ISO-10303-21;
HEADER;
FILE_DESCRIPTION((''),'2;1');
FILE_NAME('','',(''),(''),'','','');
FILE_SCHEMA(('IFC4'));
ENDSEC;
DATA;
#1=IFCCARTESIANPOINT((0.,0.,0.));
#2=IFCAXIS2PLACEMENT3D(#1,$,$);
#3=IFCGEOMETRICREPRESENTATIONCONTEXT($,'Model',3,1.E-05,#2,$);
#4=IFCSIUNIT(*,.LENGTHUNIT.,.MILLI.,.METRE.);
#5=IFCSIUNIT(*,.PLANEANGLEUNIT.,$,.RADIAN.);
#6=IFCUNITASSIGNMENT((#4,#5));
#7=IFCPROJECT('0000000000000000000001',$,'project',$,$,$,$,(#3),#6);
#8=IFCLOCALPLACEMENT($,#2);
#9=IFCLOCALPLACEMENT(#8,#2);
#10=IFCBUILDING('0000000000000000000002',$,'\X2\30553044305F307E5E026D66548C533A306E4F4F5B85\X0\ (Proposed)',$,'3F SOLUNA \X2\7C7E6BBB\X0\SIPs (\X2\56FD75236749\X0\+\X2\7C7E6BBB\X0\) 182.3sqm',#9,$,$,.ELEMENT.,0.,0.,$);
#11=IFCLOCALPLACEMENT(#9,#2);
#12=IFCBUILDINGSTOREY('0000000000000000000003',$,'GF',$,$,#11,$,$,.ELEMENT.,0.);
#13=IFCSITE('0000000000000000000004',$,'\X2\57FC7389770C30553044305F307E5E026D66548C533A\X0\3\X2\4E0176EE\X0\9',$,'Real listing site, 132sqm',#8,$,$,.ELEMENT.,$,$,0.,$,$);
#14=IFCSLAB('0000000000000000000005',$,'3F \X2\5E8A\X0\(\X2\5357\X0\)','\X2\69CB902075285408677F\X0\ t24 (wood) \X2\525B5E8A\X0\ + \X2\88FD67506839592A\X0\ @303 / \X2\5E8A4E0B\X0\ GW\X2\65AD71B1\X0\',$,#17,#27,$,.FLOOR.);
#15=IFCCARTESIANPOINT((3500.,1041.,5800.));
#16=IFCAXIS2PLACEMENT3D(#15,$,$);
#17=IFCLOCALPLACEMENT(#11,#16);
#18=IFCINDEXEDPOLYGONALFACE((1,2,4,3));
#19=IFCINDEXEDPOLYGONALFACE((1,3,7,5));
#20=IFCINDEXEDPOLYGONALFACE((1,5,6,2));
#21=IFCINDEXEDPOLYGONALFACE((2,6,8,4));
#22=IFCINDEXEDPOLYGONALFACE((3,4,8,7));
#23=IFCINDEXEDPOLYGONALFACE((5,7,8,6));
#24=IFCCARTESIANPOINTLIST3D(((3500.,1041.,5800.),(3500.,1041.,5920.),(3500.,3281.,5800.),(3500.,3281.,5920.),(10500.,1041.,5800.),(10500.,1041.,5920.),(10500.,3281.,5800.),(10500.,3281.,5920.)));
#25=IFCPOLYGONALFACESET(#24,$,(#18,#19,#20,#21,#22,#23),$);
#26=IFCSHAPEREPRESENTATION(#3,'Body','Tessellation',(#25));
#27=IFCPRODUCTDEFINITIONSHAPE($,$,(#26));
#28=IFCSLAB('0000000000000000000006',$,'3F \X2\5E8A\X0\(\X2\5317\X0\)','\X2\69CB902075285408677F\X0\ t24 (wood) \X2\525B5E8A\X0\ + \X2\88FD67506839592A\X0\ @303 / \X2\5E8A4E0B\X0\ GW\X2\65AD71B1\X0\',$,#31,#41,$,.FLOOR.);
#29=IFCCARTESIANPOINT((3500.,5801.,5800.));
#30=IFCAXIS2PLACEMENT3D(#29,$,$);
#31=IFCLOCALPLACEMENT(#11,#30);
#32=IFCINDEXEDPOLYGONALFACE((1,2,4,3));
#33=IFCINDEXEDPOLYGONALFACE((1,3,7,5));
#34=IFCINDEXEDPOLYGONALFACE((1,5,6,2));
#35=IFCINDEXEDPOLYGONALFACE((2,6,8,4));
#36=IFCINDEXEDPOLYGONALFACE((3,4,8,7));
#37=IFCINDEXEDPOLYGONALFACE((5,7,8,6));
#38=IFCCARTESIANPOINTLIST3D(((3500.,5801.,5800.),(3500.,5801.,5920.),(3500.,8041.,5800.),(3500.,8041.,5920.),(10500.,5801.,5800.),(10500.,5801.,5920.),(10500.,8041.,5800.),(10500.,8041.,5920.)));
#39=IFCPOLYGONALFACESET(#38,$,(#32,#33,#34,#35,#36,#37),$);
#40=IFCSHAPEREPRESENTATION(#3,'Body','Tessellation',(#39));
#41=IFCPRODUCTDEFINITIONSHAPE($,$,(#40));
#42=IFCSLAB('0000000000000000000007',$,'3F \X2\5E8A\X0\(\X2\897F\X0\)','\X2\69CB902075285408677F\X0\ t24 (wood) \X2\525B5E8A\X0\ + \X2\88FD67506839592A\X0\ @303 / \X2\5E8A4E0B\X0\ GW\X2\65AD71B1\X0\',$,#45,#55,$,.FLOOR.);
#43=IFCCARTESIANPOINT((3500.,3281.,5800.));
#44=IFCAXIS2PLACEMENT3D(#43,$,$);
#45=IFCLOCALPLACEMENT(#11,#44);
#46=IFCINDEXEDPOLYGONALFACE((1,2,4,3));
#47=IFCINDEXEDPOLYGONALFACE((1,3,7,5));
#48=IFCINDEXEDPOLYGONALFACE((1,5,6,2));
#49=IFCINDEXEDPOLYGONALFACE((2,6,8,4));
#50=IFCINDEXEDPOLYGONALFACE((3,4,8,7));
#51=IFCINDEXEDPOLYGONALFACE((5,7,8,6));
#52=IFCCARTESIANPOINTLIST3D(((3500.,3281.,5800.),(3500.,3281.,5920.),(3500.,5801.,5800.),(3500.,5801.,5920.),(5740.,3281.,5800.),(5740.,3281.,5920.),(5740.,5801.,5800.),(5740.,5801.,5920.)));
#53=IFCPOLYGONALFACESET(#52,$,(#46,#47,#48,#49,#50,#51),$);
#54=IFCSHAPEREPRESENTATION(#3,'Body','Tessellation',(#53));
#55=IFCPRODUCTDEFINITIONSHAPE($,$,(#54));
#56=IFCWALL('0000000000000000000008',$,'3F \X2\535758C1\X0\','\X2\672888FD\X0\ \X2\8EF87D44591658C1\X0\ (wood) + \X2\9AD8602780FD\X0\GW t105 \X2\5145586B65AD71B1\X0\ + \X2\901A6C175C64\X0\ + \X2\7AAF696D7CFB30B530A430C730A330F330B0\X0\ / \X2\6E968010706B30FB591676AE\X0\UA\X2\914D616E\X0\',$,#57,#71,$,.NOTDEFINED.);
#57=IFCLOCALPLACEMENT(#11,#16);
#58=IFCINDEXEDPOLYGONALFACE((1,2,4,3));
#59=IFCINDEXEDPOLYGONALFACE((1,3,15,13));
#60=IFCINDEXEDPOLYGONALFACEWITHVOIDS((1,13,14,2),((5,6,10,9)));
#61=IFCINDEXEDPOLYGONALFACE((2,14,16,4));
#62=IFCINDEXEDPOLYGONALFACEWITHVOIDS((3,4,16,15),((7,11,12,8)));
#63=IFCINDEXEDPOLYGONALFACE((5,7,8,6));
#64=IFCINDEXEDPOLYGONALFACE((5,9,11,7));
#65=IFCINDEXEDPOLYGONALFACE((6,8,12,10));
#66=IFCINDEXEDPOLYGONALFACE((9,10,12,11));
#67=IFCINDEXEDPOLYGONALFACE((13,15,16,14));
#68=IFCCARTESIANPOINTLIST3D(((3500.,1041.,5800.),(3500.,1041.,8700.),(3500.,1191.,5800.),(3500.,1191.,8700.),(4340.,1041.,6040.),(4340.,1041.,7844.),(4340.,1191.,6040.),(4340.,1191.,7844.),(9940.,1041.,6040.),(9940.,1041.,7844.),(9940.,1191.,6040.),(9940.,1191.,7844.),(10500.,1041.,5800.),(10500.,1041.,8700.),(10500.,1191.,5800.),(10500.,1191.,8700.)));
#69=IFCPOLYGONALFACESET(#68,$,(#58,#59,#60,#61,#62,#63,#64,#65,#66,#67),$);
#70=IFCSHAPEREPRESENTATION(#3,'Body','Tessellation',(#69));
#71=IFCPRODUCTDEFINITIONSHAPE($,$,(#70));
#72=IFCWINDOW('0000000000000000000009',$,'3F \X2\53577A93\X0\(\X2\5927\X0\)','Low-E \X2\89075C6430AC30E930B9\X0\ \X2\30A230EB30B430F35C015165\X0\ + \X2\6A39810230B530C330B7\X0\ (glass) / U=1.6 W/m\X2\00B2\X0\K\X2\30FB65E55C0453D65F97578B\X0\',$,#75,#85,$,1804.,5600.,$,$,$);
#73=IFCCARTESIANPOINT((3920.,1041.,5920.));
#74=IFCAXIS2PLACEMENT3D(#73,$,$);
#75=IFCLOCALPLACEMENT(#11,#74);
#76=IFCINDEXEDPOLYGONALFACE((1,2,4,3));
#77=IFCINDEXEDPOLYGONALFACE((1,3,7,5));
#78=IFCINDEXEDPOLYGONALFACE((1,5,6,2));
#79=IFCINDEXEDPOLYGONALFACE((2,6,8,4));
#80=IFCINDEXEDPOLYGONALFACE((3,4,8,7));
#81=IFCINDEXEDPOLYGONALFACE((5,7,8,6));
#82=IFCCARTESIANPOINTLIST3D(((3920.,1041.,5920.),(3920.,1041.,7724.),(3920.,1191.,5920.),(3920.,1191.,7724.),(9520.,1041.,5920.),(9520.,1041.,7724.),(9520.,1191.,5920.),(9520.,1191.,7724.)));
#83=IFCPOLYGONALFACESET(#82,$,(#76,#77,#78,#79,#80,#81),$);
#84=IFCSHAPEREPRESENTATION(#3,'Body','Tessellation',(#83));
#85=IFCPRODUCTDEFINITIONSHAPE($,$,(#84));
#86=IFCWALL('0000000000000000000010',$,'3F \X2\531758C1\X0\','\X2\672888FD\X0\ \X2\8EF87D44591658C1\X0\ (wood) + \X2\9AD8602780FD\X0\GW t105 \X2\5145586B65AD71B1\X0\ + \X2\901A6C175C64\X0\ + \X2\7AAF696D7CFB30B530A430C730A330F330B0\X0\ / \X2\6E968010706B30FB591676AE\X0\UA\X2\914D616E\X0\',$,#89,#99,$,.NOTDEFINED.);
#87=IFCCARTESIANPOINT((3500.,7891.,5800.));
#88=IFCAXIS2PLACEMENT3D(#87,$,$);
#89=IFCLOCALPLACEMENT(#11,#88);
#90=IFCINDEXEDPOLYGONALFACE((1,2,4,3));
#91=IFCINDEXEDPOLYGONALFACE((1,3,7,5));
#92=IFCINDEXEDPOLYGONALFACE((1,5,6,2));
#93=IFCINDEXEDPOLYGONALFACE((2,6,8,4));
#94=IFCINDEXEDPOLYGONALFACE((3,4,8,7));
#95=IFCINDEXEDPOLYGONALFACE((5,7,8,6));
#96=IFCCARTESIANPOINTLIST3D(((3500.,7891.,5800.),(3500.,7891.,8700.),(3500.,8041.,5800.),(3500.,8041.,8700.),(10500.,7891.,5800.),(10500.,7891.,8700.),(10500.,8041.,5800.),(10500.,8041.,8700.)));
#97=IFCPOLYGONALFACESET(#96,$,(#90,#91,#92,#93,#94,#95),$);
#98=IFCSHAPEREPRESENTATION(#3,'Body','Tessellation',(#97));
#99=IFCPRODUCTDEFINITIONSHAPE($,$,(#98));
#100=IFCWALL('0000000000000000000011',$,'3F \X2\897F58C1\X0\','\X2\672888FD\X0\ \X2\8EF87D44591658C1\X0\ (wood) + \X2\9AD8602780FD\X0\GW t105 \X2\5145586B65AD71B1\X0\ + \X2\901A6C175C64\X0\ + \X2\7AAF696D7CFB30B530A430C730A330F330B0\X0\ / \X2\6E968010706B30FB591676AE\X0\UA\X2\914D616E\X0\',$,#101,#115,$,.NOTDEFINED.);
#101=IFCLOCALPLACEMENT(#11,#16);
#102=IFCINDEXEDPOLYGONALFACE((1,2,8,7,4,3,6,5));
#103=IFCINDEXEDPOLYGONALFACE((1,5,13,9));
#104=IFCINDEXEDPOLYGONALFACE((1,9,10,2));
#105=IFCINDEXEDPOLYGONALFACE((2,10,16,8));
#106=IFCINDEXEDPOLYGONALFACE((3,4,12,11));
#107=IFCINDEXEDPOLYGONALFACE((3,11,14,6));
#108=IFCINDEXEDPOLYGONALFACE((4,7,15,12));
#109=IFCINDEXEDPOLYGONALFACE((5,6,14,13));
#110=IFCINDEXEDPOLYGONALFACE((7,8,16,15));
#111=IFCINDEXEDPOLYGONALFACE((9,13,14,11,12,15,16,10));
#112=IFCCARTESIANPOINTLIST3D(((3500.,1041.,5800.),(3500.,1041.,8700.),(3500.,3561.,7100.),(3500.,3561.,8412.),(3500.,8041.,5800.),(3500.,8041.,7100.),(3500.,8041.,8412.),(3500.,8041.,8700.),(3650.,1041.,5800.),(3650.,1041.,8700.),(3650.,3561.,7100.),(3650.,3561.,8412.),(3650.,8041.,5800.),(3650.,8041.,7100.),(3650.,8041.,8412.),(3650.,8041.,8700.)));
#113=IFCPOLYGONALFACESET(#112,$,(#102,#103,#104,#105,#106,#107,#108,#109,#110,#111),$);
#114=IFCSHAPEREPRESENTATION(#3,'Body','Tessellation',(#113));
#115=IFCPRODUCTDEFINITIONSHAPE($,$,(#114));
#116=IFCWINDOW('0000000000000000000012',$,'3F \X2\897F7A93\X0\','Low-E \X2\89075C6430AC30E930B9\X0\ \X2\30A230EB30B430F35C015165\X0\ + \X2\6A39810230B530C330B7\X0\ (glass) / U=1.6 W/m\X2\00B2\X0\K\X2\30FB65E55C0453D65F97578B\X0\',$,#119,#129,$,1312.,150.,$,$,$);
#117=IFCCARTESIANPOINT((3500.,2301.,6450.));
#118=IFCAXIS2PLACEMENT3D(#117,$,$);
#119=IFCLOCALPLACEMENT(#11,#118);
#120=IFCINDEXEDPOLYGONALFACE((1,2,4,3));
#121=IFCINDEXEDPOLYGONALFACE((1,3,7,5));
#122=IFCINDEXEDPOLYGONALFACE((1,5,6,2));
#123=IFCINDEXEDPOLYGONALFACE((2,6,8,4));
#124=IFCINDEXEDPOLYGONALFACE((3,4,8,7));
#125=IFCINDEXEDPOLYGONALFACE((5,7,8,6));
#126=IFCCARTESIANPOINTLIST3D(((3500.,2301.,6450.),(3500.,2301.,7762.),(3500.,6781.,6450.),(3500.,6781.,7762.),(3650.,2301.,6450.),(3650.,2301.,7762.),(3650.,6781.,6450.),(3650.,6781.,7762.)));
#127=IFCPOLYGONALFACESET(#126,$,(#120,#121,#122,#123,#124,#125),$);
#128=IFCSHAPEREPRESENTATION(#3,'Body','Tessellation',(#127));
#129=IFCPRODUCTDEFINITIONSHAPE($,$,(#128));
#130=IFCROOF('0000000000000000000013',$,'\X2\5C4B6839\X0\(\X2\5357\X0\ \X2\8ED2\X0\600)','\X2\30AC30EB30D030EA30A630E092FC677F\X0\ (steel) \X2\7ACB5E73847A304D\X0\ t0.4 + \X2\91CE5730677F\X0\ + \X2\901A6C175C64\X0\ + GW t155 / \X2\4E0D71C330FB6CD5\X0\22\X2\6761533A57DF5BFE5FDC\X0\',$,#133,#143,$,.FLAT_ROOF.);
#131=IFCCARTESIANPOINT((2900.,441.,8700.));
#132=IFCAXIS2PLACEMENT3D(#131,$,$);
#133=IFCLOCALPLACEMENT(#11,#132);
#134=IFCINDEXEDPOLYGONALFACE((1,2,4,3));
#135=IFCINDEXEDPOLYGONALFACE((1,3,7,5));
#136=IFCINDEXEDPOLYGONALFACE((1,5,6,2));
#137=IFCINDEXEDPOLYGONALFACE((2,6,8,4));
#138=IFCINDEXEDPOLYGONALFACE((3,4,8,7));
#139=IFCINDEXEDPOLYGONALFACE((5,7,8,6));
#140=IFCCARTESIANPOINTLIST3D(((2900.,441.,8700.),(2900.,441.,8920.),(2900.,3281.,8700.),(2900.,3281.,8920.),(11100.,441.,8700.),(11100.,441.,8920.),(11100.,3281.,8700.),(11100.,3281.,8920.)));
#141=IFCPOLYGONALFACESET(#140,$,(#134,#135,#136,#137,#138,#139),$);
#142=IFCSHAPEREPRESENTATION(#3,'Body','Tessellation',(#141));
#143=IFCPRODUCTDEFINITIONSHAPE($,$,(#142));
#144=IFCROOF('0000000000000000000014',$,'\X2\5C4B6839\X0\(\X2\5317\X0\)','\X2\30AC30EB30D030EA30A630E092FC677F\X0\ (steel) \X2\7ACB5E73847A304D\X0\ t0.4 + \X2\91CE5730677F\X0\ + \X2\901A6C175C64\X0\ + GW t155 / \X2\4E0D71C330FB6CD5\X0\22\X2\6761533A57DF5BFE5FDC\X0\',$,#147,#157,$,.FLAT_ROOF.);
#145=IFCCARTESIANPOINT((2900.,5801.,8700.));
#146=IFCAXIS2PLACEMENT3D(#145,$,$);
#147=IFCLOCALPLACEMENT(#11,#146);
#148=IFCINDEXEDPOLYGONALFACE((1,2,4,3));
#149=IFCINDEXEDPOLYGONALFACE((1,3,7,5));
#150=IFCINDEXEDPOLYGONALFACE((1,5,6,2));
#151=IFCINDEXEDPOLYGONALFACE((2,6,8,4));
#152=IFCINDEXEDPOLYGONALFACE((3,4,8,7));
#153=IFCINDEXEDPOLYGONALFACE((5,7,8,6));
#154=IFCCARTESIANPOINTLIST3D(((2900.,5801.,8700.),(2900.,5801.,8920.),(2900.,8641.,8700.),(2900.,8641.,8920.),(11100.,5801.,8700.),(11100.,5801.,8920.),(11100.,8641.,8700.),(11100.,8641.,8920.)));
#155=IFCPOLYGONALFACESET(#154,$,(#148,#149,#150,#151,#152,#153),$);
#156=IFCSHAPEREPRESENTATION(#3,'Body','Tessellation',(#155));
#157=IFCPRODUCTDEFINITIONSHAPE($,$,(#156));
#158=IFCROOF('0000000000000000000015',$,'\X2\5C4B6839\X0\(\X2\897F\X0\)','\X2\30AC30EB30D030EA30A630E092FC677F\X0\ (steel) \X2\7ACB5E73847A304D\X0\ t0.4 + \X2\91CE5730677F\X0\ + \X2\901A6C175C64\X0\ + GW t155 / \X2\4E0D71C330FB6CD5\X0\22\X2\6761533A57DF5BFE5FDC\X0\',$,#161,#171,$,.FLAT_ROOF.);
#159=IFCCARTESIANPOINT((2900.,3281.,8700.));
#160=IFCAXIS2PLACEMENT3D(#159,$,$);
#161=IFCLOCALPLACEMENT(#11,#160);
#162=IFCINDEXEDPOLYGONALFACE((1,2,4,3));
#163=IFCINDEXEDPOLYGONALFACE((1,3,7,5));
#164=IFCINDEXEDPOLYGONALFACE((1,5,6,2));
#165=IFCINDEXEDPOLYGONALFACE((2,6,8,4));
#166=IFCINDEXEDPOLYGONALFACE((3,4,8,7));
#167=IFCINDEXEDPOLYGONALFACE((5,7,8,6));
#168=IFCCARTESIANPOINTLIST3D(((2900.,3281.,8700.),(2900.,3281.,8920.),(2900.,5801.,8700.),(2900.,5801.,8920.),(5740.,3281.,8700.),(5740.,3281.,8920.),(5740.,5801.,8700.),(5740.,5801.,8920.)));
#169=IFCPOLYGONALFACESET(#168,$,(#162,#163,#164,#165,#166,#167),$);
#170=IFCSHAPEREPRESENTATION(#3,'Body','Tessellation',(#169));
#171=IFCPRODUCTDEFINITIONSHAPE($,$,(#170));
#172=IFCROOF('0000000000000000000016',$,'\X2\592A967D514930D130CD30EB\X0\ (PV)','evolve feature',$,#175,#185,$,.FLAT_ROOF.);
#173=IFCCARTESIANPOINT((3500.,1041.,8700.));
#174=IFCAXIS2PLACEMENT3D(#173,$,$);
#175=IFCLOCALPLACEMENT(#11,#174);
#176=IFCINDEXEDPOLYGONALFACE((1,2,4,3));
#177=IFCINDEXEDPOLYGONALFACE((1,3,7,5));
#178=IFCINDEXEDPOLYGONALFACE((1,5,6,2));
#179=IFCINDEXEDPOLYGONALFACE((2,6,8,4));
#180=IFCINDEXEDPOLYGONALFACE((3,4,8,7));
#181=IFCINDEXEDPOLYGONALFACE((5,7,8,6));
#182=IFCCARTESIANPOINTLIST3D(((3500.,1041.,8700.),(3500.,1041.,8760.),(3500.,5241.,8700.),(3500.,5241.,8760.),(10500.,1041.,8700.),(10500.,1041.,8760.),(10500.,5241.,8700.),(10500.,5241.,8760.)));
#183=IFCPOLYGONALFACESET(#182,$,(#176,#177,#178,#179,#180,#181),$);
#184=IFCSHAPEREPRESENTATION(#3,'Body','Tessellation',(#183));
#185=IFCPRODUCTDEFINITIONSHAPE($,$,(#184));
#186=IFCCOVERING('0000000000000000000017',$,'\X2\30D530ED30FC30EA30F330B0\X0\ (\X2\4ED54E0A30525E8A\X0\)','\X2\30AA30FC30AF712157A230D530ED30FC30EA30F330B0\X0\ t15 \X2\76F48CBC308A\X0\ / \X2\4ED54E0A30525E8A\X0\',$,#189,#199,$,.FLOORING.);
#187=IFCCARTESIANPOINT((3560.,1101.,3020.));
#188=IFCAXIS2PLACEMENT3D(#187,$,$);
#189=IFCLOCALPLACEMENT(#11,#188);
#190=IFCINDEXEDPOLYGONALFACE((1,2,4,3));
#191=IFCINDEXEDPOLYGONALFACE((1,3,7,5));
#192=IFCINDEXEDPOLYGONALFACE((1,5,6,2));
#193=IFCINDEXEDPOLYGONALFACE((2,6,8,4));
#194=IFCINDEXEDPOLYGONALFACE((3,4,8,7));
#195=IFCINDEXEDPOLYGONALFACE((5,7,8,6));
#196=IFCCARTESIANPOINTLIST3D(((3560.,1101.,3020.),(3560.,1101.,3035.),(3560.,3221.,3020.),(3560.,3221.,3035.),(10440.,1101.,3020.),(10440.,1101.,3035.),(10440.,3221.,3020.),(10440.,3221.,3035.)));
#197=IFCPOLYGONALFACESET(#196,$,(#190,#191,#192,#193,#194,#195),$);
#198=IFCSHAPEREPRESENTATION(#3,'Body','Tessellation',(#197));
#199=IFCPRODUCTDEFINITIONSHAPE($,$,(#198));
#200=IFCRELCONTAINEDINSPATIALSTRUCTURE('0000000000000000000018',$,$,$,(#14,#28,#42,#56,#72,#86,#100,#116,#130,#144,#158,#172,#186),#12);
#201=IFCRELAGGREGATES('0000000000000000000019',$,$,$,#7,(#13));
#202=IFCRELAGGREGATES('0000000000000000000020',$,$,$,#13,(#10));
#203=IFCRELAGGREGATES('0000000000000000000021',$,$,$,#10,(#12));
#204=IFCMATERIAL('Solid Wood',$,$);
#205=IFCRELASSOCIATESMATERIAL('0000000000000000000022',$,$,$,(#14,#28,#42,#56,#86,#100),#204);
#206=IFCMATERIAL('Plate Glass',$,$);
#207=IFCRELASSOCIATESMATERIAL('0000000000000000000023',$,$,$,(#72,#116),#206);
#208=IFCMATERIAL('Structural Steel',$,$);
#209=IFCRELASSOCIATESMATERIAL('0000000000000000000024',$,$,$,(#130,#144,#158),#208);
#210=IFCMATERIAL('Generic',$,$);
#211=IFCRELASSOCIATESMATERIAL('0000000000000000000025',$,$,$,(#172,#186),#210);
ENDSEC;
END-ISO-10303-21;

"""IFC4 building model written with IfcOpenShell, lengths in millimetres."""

from ifc_helpers import new_model, si_unit, frame, frame_2d, origin, place, context, project, spatial, rectangle, extrude, material, element, fill, save


model = new_model("IFC4")

# Units and contexts
model_context = context("Model", 3, precision=1e-05, world=origin())
ifc_project = project(units=[si_unit("LENGTHUNIT", "METRE", prefix="MILLI"), si_unit("PLANEANGLEUNIT", "RADIAN")], contexts=[model_context])

# Site, building, storey
site_placement = place(None, origin())
site = spatial("IfcSite", under=ifc_project, at=site_placement, Name="埼玉県さいたま市浦和区3丁目9", ObjectType="Real listing site, 132sqm", CompositionType="ELEMENT", RefElevation=0.0)
building_placement = place(site_placement, origin())
building = spatial("IfcBuilding", under=site, at=building_placement, Name="さいたま市浦和区の住宅 (Proposed)", ObjectType="3F SOLUNA 籾殻SIPs (国産杉+籾殻) 182.3sqm", CompositionType="ELEMENT", ElevationOfRefHeight=0.0, ElevationOfTerrain=0.0)
storey_placement = place(building_placement, origin())
storey = spatial("IfcBuildingStorey", under=building, at=storey_placement, Name="GF", CompositionType="ELEMENT", Elevation=0.0)

# Slabs
ifc_material_1 = material(Name="Solid Wood")
slab_1_placement = place(storey_placement, frame((3500.0, 1041.0, 5800.0)))
element("IfcSlab", 1, at=slab_1_placement, inside=storey, material=ifc_material_1, Name="3F 床(南)", Description="構造用合板 t24 (wood) 剛床 + 製材根太 @303 / 床下 GW断熱", PredefinedType="FLOOR", context=model_context, shape_type="SweptSolid", body=[
    extrude(rectangle(XDim=7000.0, YDim=2240.0, at=frame_2d((3500.0, 1120.0))), frame((3500.0, 1041.0, 5800.0)), (0.0, 0.0, 1.0), 120.0),
])
slab_2_placement = place(storey_placement, frame((3500.0, 5801.0, 5800.0)))
element("IfcSlab", 2, at=slab_2_placement, inside=storey, material=ifc_material_1, Name="3F 床(北)", Description="構造用合板 t24 (wood) 剛床 + 製材根太 @303 / 床下 GW断熱", PredefinedType="FLOOR", context=model_context, shape_type="SweptSolid", body=[
    extrude(rectangle(XDim=7000.0, YDim=2240.0, at=frame_2d((3500.0, 1120.0))), frame((3500.0, 5801.0, 5800.0)), (0.0, 0.0, 1.0), 120.0),
])
slab_3_placement = place(storey_placement, frame((3500.0, 3281.0, 5800.0)))
element("IfcSlab", 3, at=slab_3_placement, inside=storey, material=ifc_material_1, Name="3F 床(西)", Description="構造用合板 t24 (wood) 剛床 + 製材根太 @303 / 床下 GW断熱", PredefinedType="FLOOR", context=model_context, shape_type="SweptSolid", body=[
    extrude(rectangle(XDim=2240.0, YDim=2520.0, at=frame_2d((1120.0, 1260.0))), frame((3500.0, 3281.0, 5800.0)), (0.0, 0.0, 1.0), 120.0),
])

# Wall, opening, window
wall_1_placement = place(storey_placement, frame((3500.0, 1041.0, 5800.0)))
wall_1 = element("IfcWall", 4, at=wall_1_placement, inside=storey, material=ifc_material_1, Name="3F 南壁", Description="木製 軸組外壁 (wood) + 高性能GW t105 充填断熱 + 通気層 + 窯業系サイディング / 準耐火・外皮UA配慮", PredefinedType="NOTDEFINED", context=model_context, shape_type="SweptSolid", body=[
    extrude(rectangle(XDim=7000.0, YDim=150.0, at=frame_2d((3500.0, 75.0))), frame((3500.0, 1041.0, 5800.0)), (0.0, 0.0, 1.0), 2900.0),
])
opening_1_placement = place(storey_placement, frame((3920.0, 1041.0, 5920.0)))
opening_1 = element("IfcOpeningElement", 5, at=opening_1_placement, cuts=wall_1, PredefinedType="NOTDEFINED", context=model_context, shape_type="SweptSolid", body=[
    extrude(rectangle(XDim=5600.0, YDim=150.0, at=frame_2d((2800.0, 75.0))), frame((3920.0, 1041.0, 5920.0)), (0.0, 0.0, 1.0), 1804.0),
])
ifc_material_2 = material(Name="Plate Glass")
window_1_placement = place(storey_placement, frame((3920.0, 1041.0, 5920.0)))
window_1 = element("IfcWindow", 6, at=window_1_placement, inside=storey, material=ifc_material_2, Name="3F 南窓(大)", Description="Low-E 複層ガラス アルゴン封入 + 樹脂サッシ (glass) / U=1.6 W/m²K・日射取得型", OverallHeight=1804.0, OverallWidth=5600.0, context=model_context, shape_type="SweptSolid", body=[
    extrude(rectangle(XDim=5600.0, YDim=150.0, at=frame_2d((2800.0, 75.0))), frame((3920.0, 1041.0, 5920.0)), (0.0, 0.0, 1.0), 1804.0),
])
fill(opening_1, window_1)

# Wall
wall_2_placement = place(storey_placement, frame((3500.0, 7891.0, 5800.0)))
element("IfcWall", 7, at=wall_2_placement, inside=storey, material=ifc_material_1, Name="3F 北壁", Description="木製 軸組外壁 (wood) + 高性能GW t105 充填断熱 + 通気層 + 窯業系サイディング / 準耐火・外皮UA配慮", PredefinedType="NOTDEFINED", context=model_context, shape_type="SweptSolid", body=[
    extrude(rectangle(XDim=7000.0, YDim=150.0, at=frame_2d((3500.0, 75.0))), frame((3500.0, 7891.0, 5800.0)), (0.0, 0.0, 1.0), 2900.0),
])

# Wall, opening, window
wall_3_placement = place(storey_placement, frame((3500.0, 1041.0, 5800.0)))
wall_3 = element("IfcWall", 8, at=wall_3_placement, inside=storey, material=ifc_material_1, Name="3F 西壁", Description="木製 軸組外壁 (wood) + 高性能GW t105 充填断熱 + 通気層 + 窯業系サイディング / 準耐火・外皮UA配慮", PredefinedType="NOTDEFINED", context=model_context, shape_type="SweptSolid", body=[
    extrude(rectangle(XDim=150.0, YDim=7000.0, at=frame_2d((75.0, 3500.0))), frame((3500.0, 1041.0, 5800.0)), (0.0, 0.0, 1.0), 2900.0),
])
opening_2_placement = place(storey_placement, frame((3500.0, 2301.0, 6450.0)))
opening_2 = element("IfcOpeningElement", 9, at=opening_2_placement, cuts=wall_3, PredefinedType="NOTDEFINED", context=model_context, shape_type="SweptSolid", body=[
    extrude(rectangle(XDim=150.0, YDim=4480.0, at=frame_2d((75.0, 2240.0))), frame((3500.0, 2301.0, 6450.0)), (0.0, 0.0, 1.0), 1312.0),
])
window_2_placement = place(storey_placement, frame((3500.0, 2301.0, 6450.0)))
window_2 = element("IfcWindow", 10, at=window_2_placement, inside=storey, material=ifc_material_2, Name="3F 西窓", Description="Low-E 複層ガラス アルゴン封入 + 樹脂サッシ (glass) / U=1.6 W/m²K・日射取得型", OverallHeight=1312.0, OverallWidth=150.0, context=model_context, shape_type="SweptSolid", body=[
    extrude(rectangle(XDim=150.0, YDim=4480.0, at=frame_2d((75.0, 2240.0))), frame((3500.0, 2301.0, 6450.0)), (0.0, 0.0, 1.0), 1312.0),
])
fill(opening_2, window_2)

# Roofs
ifc_material_3 = material(Name="Structural Steel")
roof_1_placement = place(storey_placement, frame((2900.0, 441.0, 8700.0)))
element("IfcRoof", 11, at=roof_1_placement, inside=storey, material=ifc_material_3, Name="屋根(南 軒600)", Description="ガルバリウム鋼板 (steel) 立平葺き t0.4 + 野地板 + 通気層 + GW t155 / 不燃・法22条区域対応", PredefinedType="FLAT_ROOF", context=model_context, shape_type="SweptSolid", body=[
    extrude(rectangle(XDim=8200.0, YDim=2840.0, at=frame_2d((4100.0, 1420.0))), frame((2900.0, 441.0, 8700.0)), (0.0, 0.0, 1.0), 220.0),
])
roof_2_placement = place(storey_placement, frame((2900.0, 5801.0, 8700.0)))
element("IfcRoof", 12, at=roof_2_placement, inside=storey, material=ifc_material_3, Name="屋根(北)", Description="ガルバリウム鋼板 (steel) 立平葺き t0.4 + 野地板 + 通気層 + GW t155 / 不燃・法22条区域対応", PredefinedType="FLAT_ROOF", context=model_context, shape_type="SweptSolid", body=[
    extrude(rectangle(XDim=8200.0, YDim=2840.0, at=frame_2d((4100.0, 1420.0))), frame((2900.0, 5801.0, 8700.0)), (0.0, 0.0, 1.0), 220.0),
])
roof_3_placement = place(storey_placement, frame((2900.0, 3281.0, 8700.0)))
element("IfcRoof", 13, at=roof_3_placement, inside=storey, material=ifc_material_3, Name="屋根(西)", Description="ガルバリウム鋼板 (steel) 立平葺き t0.4 + 野地板 + 通気層 + GW t155 / 不燃・法22条区域対応", PredefinedType="FLAT_ROOF", context=model_context, shape_type="SweptSolid", body=[
    extrude(rectangle(XDim=2840.0, YDim=2520.0, at=frame_2d((1420.0, 1260.0))), frame((2900.0, 3281.0, 8700.0)), (0.0, 0.0, 1.0), 220.0),
])
ifc_material_4 = material(Name="Generic")
roof_4_placement = place(storey_placement, frame((3500.0, 1041.0, 8700.0)))
element("IfcRoof", 14, at=roof_4_placement, inside=storey, material=ifc_material_4, Name="太陽光パネル (PV)", Description="evolve feature", PredefinedType="FLAT_ROOF", context=model_context, shape_type="SweptSolid", body=[
    extrude(rectangle(XDim=7000.0, YDim=4200.0, at=frame_2d((3500.0, 2100.0))), frame((3500.0, 1041.0, 8700.0)), (0.0, 0.0, 1.0), 60.0),
])

# Covering
covering_1_placement = place(storey_placement, frame((3560.0, 1101.0, 3020.0)))
element("IfcCovering", 15, at=covering_1_placement, inside=storey, material=ifc_material_4, Name="フローリング (仕上げ床)", Description="オーク無垢フローリング t15 直貼り / 仕上げ床", PredefinedType="FLOORING", context=model_context, shape_type="SweptSolid", body=[
    extrude(rectangle(XDim=6880.0, YDim=2120.0, at=frame_2d((3440.0, 1060.0))), frame((3560.0, 1101.0, 3020.0)), (0.0, 0.0, 1.0), 15.0),
])

save(model, "model.ifc")
